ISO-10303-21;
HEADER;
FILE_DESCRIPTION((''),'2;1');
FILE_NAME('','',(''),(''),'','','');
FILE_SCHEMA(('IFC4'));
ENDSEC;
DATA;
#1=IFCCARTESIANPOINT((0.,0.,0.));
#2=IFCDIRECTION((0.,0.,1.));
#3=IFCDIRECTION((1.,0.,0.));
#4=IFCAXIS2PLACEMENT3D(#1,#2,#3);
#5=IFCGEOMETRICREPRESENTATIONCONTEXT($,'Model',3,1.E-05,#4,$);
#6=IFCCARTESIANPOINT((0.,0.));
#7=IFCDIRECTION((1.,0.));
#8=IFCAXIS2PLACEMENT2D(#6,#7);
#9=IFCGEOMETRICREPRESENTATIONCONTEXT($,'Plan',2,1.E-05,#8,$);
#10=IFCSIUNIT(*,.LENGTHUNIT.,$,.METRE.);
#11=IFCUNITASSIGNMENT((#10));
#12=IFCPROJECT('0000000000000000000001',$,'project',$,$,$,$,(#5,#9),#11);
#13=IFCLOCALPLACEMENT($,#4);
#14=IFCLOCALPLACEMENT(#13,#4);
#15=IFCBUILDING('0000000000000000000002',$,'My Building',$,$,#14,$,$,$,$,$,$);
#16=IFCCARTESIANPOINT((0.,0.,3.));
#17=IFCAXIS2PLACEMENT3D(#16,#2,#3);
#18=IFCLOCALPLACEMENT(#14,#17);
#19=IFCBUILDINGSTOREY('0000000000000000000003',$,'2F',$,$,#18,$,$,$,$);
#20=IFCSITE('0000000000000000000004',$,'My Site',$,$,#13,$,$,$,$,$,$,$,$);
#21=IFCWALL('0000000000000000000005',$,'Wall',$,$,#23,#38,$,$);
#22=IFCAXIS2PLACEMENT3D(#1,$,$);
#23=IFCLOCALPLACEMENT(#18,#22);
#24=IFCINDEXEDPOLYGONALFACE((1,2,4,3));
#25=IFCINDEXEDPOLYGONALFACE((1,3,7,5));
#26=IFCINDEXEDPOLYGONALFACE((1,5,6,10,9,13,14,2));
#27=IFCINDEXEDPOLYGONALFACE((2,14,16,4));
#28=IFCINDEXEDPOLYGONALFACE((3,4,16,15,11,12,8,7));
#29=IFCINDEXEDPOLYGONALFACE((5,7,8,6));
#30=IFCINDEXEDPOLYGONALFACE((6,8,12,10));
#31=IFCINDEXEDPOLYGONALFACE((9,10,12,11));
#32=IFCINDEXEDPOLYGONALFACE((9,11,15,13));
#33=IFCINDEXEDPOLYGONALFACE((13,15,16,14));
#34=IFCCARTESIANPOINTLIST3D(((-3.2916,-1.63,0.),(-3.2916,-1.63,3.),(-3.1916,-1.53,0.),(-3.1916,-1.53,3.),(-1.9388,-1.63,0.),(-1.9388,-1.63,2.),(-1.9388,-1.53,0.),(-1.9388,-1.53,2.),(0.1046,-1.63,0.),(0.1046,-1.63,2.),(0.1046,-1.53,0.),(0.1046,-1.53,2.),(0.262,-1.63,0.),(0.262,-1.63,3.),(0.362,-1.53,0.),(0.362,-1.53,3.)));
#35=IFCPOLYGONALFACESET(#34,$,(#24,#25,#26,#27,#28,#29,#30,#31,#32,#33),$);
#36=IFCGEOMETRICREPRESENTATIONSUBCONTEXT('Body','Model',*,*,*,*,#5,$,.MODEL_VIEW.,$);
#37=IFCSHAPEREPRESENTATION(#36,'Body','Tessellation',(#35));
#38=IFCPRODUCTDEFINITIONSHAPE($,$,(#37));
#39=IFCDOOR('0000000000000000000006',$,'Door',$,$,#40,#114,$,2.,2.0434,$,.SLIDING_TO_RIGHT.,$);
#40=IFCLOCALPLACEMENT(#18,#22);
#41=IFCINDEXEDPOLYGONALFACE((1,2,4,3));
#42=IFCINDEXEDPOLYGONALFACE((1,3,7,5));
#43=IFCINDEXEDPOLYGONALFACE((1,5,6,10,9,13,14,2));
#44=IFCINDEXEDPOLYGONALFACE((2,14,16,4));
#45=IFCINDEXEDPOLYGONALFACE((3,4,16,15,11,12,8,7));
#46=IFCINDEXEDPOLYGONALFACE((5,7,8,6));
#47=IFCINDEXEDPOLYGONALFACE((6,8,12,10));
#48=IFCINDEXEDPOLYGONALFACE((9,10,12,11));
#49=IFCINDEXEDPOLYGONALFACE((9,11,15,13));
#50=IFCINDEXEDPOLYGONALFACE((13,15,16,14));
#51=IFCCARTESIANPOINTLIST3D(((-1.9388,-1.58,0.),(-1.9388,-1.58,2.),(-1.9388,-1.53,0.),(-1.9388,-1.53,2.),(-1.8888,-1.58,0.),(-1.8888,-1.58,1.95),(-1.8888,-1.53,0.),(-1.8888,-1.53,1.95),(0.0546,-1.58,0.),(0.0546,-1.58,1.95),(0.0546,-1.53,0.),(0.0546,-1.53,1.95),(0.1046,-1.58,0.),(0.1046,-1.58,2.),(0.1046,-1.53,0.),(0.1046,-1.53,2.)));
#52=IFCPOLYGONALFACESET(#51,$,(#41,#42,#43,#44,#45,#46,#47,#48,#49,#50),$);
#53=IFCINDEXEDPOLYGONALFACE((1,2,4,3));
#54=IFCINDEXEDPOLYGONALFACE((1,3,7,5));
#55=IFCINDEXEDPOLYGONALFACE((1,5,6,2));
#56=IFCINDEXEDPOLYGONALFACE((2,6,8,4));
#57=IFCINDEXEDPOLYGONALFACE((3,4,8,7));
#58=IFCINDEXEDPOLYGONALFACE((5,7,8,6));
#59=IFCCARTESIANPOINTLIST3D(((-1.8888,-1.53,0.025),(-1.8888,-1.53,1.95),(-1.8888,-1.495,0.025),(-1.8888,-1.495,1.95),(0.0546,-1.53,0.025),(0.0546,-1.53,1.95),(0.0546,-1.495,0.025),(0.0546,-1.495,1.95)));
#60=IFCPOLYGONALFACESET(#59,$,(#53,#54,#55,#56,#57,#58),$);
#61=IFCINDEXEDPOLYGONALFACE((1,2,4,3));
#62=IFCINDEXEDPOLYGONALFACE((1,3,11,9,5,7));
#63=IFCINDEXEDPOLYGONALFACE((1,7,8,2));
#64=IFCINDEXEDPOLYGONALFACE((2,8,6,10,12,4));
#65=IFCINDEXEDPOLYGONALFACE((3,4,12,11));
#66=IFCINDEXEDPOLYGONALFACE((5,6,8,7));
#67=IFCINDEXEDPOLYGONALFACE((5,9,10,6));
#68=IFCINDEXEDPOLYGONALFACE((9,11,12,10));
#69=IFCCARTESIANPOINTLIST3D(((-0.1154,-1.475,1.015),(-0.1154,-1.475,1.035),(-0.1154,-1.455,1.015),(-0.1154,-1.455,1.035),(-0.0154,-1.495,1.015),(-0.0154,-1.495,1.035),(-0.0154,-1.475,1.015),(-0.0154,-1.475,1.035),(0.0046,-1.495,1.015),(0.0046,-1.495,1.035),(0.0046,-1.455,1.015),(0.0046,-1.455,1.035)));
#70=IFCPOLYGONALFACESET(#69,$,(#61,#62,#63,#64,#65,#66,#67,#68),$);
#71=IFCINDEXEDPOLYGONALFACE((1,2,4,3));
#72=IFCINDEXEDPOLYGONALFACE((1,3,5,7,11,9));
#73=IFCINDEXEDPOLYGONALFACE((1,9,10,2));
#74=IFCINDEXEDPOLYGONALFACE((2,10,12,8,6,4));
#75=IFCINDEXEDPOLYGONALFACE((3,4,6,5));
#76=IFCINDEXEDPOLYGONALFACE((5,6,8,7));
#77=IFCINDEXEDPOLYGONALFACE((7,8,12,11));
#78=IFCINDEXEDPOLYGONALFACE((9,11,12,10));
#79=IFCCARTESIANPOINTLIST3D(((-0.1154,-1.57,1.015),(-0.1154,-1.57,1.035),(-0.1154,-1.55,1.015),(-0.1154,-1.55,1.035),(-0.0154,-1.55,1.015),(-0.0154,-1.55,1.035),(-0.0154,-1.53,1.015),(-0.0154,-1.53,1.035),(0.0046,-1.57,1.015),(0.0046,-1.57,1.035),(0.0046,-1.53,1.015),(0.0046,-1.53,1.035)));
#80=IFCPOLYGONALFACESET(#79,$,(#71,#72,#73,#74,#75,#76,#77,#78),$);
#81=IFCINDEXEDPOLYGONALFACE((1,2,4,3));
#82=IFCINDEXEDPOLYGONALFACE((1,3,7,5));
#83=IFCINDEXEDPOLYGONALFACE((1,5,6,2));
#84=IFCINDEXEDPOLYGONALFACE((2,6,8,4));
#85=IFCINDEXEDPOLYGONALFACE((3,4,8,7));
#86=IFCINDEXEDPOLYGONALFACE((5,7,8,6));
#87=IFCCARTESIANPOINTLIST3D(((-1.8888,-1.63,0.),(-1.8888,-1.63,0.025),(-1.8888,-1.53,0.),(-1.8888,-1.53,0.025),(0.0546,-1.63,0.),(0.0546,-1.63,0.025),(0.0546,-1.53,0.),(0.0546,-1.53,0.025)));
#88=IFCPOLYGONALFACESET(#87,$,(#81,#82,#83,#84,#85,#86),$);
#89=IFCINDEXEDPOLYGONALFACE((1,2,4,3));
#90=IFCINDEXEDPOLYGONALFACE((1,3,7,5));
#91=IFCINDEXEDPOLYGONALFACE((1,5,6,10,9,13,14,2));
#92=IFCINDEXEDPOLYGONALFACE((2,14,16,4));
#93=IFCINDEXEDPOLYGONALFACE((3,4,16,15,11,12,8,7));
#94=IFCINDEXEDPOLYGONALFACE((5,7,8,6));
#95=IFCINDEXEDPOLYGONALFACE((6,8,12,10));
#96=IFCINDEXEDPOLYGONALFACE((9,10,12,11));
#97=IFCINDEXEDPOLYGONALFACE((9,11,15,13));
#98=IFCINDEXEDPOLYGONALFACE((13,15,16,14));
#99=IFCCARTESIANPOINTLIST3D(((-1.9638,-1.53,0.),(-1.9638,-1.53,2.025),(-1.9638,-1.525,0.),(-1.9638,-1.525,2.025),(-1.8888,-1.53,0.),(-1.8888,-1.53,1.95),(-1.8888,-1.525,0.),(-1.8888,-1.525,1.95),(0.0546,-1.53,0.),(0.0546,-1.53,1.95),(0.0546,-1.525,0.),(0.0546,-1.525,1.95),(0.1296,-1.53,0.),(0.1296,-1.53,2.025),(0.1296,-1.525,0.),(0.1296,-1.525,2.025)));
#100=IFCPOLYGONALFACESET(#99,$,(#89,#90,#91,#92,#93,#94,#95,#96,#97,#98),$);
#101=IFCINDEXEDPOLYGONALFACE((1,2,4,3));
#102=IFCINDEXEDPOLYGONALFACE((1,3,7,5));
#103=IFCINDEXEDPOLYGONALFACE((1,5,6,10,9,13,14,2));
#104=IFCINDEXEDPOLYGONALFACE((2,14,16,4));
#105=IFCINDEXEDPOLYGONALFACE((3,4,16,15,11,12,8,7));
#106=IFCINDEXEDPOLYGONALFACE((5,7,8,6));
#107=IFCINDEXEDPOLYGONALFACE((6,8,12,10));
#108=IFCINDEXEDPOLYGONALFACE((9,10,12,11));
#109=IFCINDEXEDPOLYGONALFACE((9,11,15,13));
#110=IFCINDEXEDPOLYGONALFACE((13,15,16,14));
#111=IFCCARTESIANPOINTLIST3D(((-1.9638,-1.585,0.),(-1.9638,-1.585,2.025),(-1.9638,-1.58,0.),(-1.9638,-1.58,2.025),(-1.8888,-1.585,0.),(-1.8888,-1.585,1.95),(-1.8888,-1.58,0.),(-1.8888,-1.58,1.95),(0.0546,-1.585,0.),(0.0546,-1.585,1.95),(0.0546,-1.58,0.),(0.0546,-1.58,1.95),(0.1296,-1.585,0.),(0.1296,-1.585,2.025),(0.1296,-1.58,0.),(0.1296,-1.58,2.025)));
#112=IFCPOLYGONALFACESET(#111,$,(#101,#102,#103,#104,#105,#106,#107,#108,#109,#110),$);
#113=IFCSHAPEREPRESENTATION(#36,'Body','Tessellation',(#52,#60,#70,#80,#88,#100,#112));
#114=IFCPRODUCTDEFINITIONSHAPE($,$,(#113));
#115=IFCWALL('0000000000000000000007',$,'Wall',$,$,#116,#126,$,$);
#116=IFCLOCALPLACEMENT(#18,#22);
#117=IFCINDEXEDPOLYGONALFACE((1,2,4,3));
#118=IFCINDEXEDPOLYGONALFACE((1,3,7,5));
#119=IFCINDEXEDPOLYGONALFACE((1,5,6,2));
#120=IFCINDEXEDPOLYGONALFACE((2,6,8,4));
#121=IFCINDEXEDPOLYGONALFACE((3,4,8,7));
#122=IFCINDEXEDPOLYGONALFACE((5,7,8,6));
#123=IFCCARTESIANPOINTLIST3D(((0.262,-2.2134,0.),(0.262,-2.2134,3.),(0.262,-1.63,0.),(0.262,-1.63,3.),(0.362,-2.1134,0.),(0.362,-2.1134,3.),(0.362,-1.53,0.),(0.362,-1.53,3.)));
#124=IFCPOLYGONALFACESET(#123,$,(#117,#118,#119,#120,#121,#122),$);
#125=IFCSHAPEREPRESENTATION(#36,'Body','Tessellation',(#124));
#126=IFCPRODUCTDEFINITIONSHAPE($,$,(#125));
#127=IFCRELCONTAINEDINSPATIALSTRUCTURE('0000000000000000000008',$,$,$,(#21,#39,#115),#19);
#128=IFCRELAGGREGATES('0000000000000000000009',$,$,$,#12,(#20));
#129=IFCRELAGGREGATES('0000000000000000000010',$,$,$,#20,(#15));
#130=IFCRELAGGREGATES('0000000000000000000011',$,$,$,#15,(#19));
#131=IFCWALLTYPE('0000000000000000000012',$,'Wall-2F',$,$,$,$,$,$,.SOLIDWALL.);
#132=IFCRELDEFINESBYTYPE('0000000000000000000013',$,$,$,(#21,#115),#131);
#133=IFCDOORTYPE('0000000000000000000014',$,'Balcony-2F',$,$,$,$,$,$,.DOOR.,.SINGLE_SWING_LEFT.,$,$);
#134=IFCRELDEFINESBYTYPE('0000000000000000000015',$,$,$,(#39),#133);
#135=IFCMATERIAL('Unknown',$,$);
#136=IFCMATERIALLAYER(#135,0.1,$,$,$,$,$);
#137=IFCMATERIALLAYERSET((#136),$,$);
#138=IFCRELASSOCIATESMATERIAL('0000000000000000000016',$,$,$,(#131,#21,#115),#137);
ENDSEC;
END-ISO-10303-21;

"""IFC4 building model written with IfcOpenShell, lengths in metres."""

from ifc_helpers import new_model, entity, si_unit, frame, origin_with_axes, origin_2d_with_axis, place, context, subcontext, project, spatial, line, indexed_curve, outline, extrude, shape, source, transform, mapped, material, layer, layer_set, layer_usage, type_object, type_shapes, element, fill, save


model = new_model("IFC4")

# Units and contexts
model_context = context("Model", 3, precision=1e-05, world=origin_with_axes())
plan_context = context("Plan", 2, precision=1e-05, world=origin_2d_with_axis())
body_context_1 = subcontext(model_context, "Body", "Model", "MODEL_VIEW")
body_context_2 = subcontext(plan_context, "Body", "Plan", "PLAN_VIEW")
ifc_project = project(units=[si_unit("LENGTHUNIT", "METRE")], contexts=[model_context, plan_context])

# Site, building, storey
site_placement = place(None, origin_with_axes())
site = spatial("IfcSite", under=ifc_project, at=site_placement, Name="My Site")
building_placement = place(site_placement, origin_with_axes())
building = spatial("IfcBuilding", under=site, at=building_placement, Name="My Building")
storey_placement = place(building_placement, frame((0.0, 0.0, 3.0), z_axis=(0.0, 0.0, 1.0), x_axis=(1.0, 0.0, 0.0)))
storey = spatial("IfcBuildingStorey", under=building, at=storey_placement, Name="2F")

# Shared definitions
ifc_material = material(Name="Unknown")
ifc_layer_1 = layer(ifc_material, 0.1)
ifc_layer_set_1 = layer_set([ifc_layer_1])
wall_type_1 = type_object("IfcWallType", Name="Wall-2F", PredefinedType="SOLIDWALL", material=ifc_layer_set_1)

# Wall, opening, door
ifc_layer_usage_1 = layer_usage(ifc_layer_set_1, "AXIS2", "POSITIVE", 0.0)
wall_1_placement = place(storey_placement, frame((-3.2916, -1.63, 0.0), z_axis=(0.0, 0.0, 1.0), x_axis=(1.0, 0.0, 0.0)))
wall_1 = element("IfcWall", 1, at=wall_1_placement, inside=storey, type_object=wall_type_1, material=ifc_layer_usage_1, Name="Wall", context=body_context_1, shape_type="SweptSolid", body=[
    extrude(outline(indexed_curve([(0.0, 0.0), (0.1, 0.1), (3.6537, 0.1), (3.5537, 0.0)], segments=[line(1, 2, 3, 4, 1)])), origin_with_axes(), (0.0, 0.0, 1.0), 3.0),
])
shared_shape_1 = source(origin_with_axes(), body_context_1, "Body", "SweptSolid", [
    extrude(outline(indexed_curve([(0.0, 0.0), (2.0434, 0.0), (2.0434, 2.0), (0.0, 2.0)], segments=[line(1, 2, 3, 4, 1)])), frame((0.0, -0.6, 0.0), z_axis=(0.0, -1.0, 0.0), x_axis=(1.0, 0.0, 0.0)), (0.0, 0.0, -1.0), 1.2),
])
opening_1_placement = place(wall_1_placement, frame((3.3963, 0.1, 0.0), z_axis=(0.0, 0.0, 1.0), x_axis=(-1.0, 0.0, 0.0)))
opening_1 = element("IfcOpeningElement", 2, at=opening_1_placement, cuts=wall_1, PredefinedType="OPENING", context=body_context_1, shape_type="MappedRepresentation", body=[
    mapped(shared_shape_1, transform((0.0, 0.0, 0.0), x_axis=(1.0, 0.0, 0.0), y_axis=(0.0, 1.0, 0.0), z_axis=(0.0, 0.0, 1.0), scale=1.0)),
])
door_type_1 = type_object("IfcDoorType", Name="Balcony-2F", OperationType="SINGLE_SWING_LEFT", PredefinedType="DOOR")
shared_shape_2 = source(origin_with_axes(), body_context_1, "Body", "SweptSolid", [
    extrude(outline(indexed_curve([(0.0, 0.0), (0.0, 2.0), (2.0434, 2.0), (2.0434, 0.0), (1.9934, 0.0), (1.9934, 1.95), (0.05, 1.95), (0.05, 0.0)], segments=[line(1, 2, 3, 4, 5, 6, 7, 8, 1)])), frame((0.0, 0.0, 0.0), z_axis=(0.0, -1.0, 0.0), x_axis=(1.0, 0.0, 0.0)), (0.0, 0.0, -1.0), 0.05),
    extrude(outline(indexed_curve([(0.0, 0.0), (1.9434, 0.0), (1.9434, 0.035), (0.0, 0.035)], segments=[line(1, 2, 3, 4, 1)])), frame((0.05, -0.035, 0.025), z_axis=(0.0, 0.0, 1.0), x_axis=(1.0, 0.0, 0.0)), (0.0, 0.0, 1.0), 1.925),
    extrude(outline(indexed_curve([(0.0, 0.0), (0.0, -0.04), (0.12, -0.04), (0.12, -0.02), (0.02, -0.02), (0.02, 0.0)], segments=[line(1, 2, 3, 4, 5, 6, 1)])), frame((0.1, -0.035, 1.015), z_axis=(0.0, 0.0, 1.0), x_axis=(1.0, 0.0, 0.0)), (0.0, 0.0, 1.0), 0.02),
    extrude(outline(indexed_curve([(0.0, 0.0), (0.0, 0.04), (0.12, 0.04), (0.12, 0.02), (0.02, 0.02), (0.02, 0.0)], segments=[line(1, 2, 3, 4, 5, 6, 1)])), frame((0.1, 0.0, 1.015), z_axis=(0.0, 0.0, 1.0), x_axis=(1.0, 0.0, 0.0)), (0.0, 0.0, 1.0), 0.02),
    extrude(outline(indexed_curve([(0.0, 0.0), (1.9434, 0.0), (1.9434, 0.1), (0.0, 0.1)], segments=[line(1, 2, 3, 4, 1)])), frame((0.05, 0.0, 0.0), z_axis=(0.0, 0.0, 1.0), x_axis=(1.0, 0.0, 0.0)), (0.0, 0.0, 1.0), 0.025),
    extrude(outline(indexed_curve([(0.0, 0.0), (0.0, 2.025), (2.0934, 2.025), (2.0934, 0.0), (2.0184, 0.0), (2.0184, 1.95), (0.075, 1.95), (0.075, 0.0)], segments=[line(1, 2, 3, 4, 5, 6, 7, 8, 1)])), frame((-0.025, -0.005, 0.0), z_axis=(0.0, -1.0, 0.0), x_axis=(1.0, 0.0, 0.0)), (0.0, 0.0, -1.0), 0.005),
    extrude(outline(indexed_curve([(0.0, 0.0), (0.0, 2.025), (2.0934, 2.025), (2.0934, 0.0), (2.0184, 0.0), (2.0184, 1.95), (0.075, 1.95), (0.075, 0.0)], segments=[line(1, 2, 3, 4, 5, 6, 7, 8, 1)])), frame((-0.025, 0.05, 0.0), z_axis=(0.0, -1.0, 0.0), x_axis=(1.0, 0.0, 0.0)), (0.0, 0.0, -1.0), 0.005),
])
shared_shape_3 = source(origin_with_axes(), body_context_2, "Body", "Curve2D", [
    entity("IfcIndexedPolyCurve", entity("IfcCartesianPointList2D", [[0.0, 0.0], [0.05, 0.0], [0.05, 0.05], [0.0, 0.05]]), [entity("IfcLineIndex", [1, 2, 3, 4, 1])]),
    entity("IfcIndexedPolyCurve", entity("IfcCartesianPointList2D", [[2.0434, 0.0], [1.9934, 0.0], [1.9934, 0.05], [2.0434, 0.05]]), [entity("IfcLineIndex", [1, 2, 3, 4, 1])]),
    entity("IfcIndexedPolyCurve", entity("IfcCartesianPointList2D", [[2.965, -0.035], [1.0217, -0.035], [1.0217, 0.0], [2.965, 0.0]]), [entity("IfcLineIndex", [1, 2, 3, 4, 1])]),
])
type_shapes(door_type_1, [shared_shape_2, shared_shape_3])
door_1_placement = place(opening_1_placement, frame((0.0, 0.0, 0.0), z_axis=(0.0, 0.0, 1.0), x_axis=(1.0, 0.0, 0.0)))
door_1 = element("IfcDoor", 3, at=door_1_placement, inside=storey, type_object=door_type_1, Name="Door", OperationType="SLIDING_TO_RIGHT", OverallHeight=2.0, OverallWidth=2.0434, shapes=[
    shape(body_context_1, "Body", "MappedRepresentation", [mapped(shared_shape_2, transform((0.0, 0.0, 0.0), x_axis=(1.0, 0.0, 0.0), y_axis=(0.0, 1.0, 0.0), z_axis=(0.0, 0.0, 1.0), scale=1.0))]),
    shape(body_context_2, "Body", "MappedRepresentation", [mapped(shared_shape_3, transform((0.0, 0.0, 0.0), x_axis=(1.0, 0.0, 0.0), y_axis=(0.0, 1.0, 0.0), z_axis=(0.0, 0.0, 1.0), scale=1.0))]),
])
fill(opening_1, door_1)

# Wall
ifc_layer_usage_2 = layer_usage(ifc_layer_set_1, "AXIS2", "POSITIVE", 0.0)
wall_2_placement = place(storey_placement, frame((0.262, -1.63, 0.0), z_axis=(0.0, 0.0, 1.0), x_axis=(0.000001, -1.0, 0.0)))
element("IfcWall", 4, at=wall_2_placement, inside=storey, type_object=wall_type_1, material=ifc_layer_usage_2, Name="Wall", context=body_context_1, shape_type="SweptSolid", body=[
    extrude(outline(indexed_curve([(0.0, 0.0), (-0.1, 0.1), (0.4834, 0.1), (0.5834, 0.0)], segments=[line(1, 2, 3, 4, 1)])), origin_with_axes(), (0.0, 0.0, 1.0), 3.0),
])

save(model, "model.ifc")
